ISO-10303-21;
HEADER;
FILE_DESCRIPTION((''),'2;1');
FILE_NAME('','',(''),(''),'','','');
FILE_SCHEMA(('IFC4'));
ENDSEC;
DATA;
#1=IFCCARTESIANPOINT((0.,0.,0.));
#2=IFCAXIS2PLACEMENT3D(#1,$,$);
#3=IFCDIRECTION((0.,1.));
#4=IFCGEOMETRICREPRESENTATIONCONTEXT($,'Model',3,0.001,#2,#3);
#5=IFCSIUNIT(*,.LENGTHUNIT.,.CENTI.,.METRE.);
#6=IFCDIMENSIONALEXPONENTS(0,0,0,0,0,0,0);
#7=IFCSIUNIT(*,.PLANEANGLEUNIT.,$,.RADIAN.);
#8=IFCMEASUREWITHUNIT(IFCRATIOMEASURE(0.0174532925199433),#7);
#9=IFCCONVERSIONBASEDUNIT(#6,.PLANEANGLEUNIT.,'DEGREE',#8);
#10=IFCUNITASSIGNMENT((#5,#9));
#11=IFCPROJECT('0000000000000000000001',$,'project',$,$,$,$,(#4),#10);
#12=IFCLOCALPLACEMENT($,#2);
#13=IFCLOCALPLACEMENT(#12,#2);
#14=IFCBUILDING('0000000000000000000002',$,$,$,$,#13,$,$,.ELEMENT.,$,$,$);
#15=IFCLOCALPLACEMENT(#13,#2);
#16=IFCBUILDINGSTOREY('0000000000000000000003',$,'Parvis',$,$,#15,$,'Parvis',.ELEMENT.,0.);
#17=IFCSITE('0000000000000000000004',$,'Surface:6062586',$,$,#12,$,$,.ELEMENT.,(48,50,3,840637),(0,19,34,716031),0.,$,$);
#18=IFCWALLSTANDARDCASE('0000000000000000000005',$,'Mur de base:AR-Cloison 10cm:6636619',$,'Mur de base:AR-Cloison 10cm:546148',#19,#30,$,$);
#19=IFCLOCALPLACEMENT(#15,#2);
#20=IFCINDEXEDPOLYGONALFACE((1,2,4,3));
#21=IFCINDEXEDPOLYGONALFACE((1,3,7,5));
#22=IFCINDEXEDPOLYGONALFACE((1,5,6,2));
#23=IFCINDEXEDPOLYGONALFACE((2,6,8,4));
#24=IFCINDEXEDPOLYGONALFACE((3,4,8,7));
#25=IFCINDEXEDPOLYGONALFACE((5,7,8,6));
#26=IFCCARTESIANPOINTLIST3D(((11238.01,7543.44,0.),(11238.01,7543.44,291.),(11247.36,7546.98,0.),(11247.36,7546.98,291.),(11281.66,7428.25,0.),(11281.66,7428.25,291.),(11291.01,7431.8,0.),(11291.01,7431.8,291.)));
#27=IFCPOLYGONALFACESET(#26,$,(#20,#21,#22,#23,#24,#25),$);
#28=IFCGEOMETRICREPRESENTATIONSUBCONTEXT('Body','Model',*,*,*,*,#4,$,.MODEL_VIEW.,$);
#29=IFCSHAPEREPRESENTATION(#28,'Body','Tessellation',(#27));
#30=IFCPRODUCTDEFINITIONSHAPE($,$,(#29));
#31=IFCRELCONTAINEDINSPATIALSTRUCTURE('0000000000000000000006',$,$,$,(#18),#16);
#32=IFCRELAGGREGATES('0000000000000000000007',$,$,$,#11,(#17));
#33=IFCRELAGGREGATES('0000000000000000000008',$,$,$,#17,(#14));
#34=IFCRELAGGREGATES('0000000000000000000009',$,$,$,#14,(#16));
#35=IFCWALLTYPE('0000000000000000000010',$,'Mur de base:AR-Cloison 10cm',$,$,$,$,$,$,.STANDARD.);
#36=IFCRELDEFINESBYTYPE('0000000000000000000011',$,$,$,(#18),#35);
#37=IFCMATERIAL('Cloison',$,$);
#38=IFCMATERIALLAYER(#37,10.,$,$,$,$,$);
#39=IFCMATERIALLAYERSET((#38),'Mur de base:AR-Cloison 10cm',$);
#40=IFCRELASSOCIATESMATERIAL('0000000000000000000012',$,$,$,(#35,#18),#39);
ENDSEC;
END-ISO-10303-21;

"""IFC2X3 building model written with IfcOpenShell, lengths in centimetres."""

from ifc_helpers import new_model, entity, si_unit, converted_unit, direction, frame, frame_2d, origin, place, context, subcontext, project, spatial, rectangle, extrude, material, layer, layer_set, layer_usage, type_object, element, save


model = new_model("IFC2X3")

# Units and contexts
model_context = context("Model", 3, precision=0.001, world=origin(), true_north=direction((0.0, 1.0)))
body_context = subcontext(model_context, "Body", "Model", "MODEL_VIEW")
ifc_project = project(units=[si_unit("LENGTHUNIT", "METRE", prefix="CENTI"), converted_unit("PLANEANGLEUNIT", "DEGREE", entity("IfcRatioMeasure", 0.0174532925199433), si_unit("PLANEANGLEUNIT", "RADIAN"), dimensions=[0, 0, 0, 0, 0, 0, 0])], contexts=[model_context])

# Site, building, storey
site_placement = place(None, origin())
site = spatial("IfcSite", under=ifc_project, at=site_placement, Name="Surface:6062586", CompositionType="ELEMENT", RefLatitude=(48, 50, 3, 840637), RefLongitude=(0, 19, 34, 716031), RefElevation=0.0)
building_placement = place(site_placement, origin())
building = spatial("IfcBuilding", under=site, at=building_placement, CompositionType="ELEMENT")
storey_placement = place(building_placement, frame((0.0, 0.0, 0.0)))
storey = spatial("IfcBuildingStorey", under=building, at=storey_placement, Name="Parvis", LongName="Parvis", CompositionType="ELEMENT", Elevation=0.0)

# Wall
ifc_material_1 = material(Name="Cloison")
ifc_layer_1 = layer(ifc_material_1, 10.0)
ifc_layer_set_1 = layer_set([ifc_layer_1], Name="Mur de base:AR-Cloison 10cm")
ifc_layer_usage_1 = layer_usage(ifc_layer_set_1, "AXIS2", "NEGATIVE", 5.0)
wall_type = type_object("IfcWallType", Name="Mur de base:AR-Cloison 10cm", PredefinedType="STANDARD", material=ifc_layer_set_1)
wall_placement = place(storey_placement, frame((11242.68, 7545.21, 0.0), z_axis=(0.0, 0.0, 1.0), x_axis=(0.354376, -0.935103, 0.0)))
element("IfcWallStandardCase", 1, at=wall_placement, inside=storey, type_object=wall_type, material=ifc_layer_usage_1, Name="Mur de base:AR-Cloison 10cm:6636619", ObjectType="Mur de base:AR-Cloison 10cm:546148", context=body_context, shape_type="SweptSolid", body=[
    extrude(rectangle(XDim=123.18, YDim=10.0, at=frame_2d((61.59, 0.0), x_axis=(-1.0, 0.0))), origin(), (0.0, 0.0, 1.0), 291.0),
])

save(model, "model.ifc")
